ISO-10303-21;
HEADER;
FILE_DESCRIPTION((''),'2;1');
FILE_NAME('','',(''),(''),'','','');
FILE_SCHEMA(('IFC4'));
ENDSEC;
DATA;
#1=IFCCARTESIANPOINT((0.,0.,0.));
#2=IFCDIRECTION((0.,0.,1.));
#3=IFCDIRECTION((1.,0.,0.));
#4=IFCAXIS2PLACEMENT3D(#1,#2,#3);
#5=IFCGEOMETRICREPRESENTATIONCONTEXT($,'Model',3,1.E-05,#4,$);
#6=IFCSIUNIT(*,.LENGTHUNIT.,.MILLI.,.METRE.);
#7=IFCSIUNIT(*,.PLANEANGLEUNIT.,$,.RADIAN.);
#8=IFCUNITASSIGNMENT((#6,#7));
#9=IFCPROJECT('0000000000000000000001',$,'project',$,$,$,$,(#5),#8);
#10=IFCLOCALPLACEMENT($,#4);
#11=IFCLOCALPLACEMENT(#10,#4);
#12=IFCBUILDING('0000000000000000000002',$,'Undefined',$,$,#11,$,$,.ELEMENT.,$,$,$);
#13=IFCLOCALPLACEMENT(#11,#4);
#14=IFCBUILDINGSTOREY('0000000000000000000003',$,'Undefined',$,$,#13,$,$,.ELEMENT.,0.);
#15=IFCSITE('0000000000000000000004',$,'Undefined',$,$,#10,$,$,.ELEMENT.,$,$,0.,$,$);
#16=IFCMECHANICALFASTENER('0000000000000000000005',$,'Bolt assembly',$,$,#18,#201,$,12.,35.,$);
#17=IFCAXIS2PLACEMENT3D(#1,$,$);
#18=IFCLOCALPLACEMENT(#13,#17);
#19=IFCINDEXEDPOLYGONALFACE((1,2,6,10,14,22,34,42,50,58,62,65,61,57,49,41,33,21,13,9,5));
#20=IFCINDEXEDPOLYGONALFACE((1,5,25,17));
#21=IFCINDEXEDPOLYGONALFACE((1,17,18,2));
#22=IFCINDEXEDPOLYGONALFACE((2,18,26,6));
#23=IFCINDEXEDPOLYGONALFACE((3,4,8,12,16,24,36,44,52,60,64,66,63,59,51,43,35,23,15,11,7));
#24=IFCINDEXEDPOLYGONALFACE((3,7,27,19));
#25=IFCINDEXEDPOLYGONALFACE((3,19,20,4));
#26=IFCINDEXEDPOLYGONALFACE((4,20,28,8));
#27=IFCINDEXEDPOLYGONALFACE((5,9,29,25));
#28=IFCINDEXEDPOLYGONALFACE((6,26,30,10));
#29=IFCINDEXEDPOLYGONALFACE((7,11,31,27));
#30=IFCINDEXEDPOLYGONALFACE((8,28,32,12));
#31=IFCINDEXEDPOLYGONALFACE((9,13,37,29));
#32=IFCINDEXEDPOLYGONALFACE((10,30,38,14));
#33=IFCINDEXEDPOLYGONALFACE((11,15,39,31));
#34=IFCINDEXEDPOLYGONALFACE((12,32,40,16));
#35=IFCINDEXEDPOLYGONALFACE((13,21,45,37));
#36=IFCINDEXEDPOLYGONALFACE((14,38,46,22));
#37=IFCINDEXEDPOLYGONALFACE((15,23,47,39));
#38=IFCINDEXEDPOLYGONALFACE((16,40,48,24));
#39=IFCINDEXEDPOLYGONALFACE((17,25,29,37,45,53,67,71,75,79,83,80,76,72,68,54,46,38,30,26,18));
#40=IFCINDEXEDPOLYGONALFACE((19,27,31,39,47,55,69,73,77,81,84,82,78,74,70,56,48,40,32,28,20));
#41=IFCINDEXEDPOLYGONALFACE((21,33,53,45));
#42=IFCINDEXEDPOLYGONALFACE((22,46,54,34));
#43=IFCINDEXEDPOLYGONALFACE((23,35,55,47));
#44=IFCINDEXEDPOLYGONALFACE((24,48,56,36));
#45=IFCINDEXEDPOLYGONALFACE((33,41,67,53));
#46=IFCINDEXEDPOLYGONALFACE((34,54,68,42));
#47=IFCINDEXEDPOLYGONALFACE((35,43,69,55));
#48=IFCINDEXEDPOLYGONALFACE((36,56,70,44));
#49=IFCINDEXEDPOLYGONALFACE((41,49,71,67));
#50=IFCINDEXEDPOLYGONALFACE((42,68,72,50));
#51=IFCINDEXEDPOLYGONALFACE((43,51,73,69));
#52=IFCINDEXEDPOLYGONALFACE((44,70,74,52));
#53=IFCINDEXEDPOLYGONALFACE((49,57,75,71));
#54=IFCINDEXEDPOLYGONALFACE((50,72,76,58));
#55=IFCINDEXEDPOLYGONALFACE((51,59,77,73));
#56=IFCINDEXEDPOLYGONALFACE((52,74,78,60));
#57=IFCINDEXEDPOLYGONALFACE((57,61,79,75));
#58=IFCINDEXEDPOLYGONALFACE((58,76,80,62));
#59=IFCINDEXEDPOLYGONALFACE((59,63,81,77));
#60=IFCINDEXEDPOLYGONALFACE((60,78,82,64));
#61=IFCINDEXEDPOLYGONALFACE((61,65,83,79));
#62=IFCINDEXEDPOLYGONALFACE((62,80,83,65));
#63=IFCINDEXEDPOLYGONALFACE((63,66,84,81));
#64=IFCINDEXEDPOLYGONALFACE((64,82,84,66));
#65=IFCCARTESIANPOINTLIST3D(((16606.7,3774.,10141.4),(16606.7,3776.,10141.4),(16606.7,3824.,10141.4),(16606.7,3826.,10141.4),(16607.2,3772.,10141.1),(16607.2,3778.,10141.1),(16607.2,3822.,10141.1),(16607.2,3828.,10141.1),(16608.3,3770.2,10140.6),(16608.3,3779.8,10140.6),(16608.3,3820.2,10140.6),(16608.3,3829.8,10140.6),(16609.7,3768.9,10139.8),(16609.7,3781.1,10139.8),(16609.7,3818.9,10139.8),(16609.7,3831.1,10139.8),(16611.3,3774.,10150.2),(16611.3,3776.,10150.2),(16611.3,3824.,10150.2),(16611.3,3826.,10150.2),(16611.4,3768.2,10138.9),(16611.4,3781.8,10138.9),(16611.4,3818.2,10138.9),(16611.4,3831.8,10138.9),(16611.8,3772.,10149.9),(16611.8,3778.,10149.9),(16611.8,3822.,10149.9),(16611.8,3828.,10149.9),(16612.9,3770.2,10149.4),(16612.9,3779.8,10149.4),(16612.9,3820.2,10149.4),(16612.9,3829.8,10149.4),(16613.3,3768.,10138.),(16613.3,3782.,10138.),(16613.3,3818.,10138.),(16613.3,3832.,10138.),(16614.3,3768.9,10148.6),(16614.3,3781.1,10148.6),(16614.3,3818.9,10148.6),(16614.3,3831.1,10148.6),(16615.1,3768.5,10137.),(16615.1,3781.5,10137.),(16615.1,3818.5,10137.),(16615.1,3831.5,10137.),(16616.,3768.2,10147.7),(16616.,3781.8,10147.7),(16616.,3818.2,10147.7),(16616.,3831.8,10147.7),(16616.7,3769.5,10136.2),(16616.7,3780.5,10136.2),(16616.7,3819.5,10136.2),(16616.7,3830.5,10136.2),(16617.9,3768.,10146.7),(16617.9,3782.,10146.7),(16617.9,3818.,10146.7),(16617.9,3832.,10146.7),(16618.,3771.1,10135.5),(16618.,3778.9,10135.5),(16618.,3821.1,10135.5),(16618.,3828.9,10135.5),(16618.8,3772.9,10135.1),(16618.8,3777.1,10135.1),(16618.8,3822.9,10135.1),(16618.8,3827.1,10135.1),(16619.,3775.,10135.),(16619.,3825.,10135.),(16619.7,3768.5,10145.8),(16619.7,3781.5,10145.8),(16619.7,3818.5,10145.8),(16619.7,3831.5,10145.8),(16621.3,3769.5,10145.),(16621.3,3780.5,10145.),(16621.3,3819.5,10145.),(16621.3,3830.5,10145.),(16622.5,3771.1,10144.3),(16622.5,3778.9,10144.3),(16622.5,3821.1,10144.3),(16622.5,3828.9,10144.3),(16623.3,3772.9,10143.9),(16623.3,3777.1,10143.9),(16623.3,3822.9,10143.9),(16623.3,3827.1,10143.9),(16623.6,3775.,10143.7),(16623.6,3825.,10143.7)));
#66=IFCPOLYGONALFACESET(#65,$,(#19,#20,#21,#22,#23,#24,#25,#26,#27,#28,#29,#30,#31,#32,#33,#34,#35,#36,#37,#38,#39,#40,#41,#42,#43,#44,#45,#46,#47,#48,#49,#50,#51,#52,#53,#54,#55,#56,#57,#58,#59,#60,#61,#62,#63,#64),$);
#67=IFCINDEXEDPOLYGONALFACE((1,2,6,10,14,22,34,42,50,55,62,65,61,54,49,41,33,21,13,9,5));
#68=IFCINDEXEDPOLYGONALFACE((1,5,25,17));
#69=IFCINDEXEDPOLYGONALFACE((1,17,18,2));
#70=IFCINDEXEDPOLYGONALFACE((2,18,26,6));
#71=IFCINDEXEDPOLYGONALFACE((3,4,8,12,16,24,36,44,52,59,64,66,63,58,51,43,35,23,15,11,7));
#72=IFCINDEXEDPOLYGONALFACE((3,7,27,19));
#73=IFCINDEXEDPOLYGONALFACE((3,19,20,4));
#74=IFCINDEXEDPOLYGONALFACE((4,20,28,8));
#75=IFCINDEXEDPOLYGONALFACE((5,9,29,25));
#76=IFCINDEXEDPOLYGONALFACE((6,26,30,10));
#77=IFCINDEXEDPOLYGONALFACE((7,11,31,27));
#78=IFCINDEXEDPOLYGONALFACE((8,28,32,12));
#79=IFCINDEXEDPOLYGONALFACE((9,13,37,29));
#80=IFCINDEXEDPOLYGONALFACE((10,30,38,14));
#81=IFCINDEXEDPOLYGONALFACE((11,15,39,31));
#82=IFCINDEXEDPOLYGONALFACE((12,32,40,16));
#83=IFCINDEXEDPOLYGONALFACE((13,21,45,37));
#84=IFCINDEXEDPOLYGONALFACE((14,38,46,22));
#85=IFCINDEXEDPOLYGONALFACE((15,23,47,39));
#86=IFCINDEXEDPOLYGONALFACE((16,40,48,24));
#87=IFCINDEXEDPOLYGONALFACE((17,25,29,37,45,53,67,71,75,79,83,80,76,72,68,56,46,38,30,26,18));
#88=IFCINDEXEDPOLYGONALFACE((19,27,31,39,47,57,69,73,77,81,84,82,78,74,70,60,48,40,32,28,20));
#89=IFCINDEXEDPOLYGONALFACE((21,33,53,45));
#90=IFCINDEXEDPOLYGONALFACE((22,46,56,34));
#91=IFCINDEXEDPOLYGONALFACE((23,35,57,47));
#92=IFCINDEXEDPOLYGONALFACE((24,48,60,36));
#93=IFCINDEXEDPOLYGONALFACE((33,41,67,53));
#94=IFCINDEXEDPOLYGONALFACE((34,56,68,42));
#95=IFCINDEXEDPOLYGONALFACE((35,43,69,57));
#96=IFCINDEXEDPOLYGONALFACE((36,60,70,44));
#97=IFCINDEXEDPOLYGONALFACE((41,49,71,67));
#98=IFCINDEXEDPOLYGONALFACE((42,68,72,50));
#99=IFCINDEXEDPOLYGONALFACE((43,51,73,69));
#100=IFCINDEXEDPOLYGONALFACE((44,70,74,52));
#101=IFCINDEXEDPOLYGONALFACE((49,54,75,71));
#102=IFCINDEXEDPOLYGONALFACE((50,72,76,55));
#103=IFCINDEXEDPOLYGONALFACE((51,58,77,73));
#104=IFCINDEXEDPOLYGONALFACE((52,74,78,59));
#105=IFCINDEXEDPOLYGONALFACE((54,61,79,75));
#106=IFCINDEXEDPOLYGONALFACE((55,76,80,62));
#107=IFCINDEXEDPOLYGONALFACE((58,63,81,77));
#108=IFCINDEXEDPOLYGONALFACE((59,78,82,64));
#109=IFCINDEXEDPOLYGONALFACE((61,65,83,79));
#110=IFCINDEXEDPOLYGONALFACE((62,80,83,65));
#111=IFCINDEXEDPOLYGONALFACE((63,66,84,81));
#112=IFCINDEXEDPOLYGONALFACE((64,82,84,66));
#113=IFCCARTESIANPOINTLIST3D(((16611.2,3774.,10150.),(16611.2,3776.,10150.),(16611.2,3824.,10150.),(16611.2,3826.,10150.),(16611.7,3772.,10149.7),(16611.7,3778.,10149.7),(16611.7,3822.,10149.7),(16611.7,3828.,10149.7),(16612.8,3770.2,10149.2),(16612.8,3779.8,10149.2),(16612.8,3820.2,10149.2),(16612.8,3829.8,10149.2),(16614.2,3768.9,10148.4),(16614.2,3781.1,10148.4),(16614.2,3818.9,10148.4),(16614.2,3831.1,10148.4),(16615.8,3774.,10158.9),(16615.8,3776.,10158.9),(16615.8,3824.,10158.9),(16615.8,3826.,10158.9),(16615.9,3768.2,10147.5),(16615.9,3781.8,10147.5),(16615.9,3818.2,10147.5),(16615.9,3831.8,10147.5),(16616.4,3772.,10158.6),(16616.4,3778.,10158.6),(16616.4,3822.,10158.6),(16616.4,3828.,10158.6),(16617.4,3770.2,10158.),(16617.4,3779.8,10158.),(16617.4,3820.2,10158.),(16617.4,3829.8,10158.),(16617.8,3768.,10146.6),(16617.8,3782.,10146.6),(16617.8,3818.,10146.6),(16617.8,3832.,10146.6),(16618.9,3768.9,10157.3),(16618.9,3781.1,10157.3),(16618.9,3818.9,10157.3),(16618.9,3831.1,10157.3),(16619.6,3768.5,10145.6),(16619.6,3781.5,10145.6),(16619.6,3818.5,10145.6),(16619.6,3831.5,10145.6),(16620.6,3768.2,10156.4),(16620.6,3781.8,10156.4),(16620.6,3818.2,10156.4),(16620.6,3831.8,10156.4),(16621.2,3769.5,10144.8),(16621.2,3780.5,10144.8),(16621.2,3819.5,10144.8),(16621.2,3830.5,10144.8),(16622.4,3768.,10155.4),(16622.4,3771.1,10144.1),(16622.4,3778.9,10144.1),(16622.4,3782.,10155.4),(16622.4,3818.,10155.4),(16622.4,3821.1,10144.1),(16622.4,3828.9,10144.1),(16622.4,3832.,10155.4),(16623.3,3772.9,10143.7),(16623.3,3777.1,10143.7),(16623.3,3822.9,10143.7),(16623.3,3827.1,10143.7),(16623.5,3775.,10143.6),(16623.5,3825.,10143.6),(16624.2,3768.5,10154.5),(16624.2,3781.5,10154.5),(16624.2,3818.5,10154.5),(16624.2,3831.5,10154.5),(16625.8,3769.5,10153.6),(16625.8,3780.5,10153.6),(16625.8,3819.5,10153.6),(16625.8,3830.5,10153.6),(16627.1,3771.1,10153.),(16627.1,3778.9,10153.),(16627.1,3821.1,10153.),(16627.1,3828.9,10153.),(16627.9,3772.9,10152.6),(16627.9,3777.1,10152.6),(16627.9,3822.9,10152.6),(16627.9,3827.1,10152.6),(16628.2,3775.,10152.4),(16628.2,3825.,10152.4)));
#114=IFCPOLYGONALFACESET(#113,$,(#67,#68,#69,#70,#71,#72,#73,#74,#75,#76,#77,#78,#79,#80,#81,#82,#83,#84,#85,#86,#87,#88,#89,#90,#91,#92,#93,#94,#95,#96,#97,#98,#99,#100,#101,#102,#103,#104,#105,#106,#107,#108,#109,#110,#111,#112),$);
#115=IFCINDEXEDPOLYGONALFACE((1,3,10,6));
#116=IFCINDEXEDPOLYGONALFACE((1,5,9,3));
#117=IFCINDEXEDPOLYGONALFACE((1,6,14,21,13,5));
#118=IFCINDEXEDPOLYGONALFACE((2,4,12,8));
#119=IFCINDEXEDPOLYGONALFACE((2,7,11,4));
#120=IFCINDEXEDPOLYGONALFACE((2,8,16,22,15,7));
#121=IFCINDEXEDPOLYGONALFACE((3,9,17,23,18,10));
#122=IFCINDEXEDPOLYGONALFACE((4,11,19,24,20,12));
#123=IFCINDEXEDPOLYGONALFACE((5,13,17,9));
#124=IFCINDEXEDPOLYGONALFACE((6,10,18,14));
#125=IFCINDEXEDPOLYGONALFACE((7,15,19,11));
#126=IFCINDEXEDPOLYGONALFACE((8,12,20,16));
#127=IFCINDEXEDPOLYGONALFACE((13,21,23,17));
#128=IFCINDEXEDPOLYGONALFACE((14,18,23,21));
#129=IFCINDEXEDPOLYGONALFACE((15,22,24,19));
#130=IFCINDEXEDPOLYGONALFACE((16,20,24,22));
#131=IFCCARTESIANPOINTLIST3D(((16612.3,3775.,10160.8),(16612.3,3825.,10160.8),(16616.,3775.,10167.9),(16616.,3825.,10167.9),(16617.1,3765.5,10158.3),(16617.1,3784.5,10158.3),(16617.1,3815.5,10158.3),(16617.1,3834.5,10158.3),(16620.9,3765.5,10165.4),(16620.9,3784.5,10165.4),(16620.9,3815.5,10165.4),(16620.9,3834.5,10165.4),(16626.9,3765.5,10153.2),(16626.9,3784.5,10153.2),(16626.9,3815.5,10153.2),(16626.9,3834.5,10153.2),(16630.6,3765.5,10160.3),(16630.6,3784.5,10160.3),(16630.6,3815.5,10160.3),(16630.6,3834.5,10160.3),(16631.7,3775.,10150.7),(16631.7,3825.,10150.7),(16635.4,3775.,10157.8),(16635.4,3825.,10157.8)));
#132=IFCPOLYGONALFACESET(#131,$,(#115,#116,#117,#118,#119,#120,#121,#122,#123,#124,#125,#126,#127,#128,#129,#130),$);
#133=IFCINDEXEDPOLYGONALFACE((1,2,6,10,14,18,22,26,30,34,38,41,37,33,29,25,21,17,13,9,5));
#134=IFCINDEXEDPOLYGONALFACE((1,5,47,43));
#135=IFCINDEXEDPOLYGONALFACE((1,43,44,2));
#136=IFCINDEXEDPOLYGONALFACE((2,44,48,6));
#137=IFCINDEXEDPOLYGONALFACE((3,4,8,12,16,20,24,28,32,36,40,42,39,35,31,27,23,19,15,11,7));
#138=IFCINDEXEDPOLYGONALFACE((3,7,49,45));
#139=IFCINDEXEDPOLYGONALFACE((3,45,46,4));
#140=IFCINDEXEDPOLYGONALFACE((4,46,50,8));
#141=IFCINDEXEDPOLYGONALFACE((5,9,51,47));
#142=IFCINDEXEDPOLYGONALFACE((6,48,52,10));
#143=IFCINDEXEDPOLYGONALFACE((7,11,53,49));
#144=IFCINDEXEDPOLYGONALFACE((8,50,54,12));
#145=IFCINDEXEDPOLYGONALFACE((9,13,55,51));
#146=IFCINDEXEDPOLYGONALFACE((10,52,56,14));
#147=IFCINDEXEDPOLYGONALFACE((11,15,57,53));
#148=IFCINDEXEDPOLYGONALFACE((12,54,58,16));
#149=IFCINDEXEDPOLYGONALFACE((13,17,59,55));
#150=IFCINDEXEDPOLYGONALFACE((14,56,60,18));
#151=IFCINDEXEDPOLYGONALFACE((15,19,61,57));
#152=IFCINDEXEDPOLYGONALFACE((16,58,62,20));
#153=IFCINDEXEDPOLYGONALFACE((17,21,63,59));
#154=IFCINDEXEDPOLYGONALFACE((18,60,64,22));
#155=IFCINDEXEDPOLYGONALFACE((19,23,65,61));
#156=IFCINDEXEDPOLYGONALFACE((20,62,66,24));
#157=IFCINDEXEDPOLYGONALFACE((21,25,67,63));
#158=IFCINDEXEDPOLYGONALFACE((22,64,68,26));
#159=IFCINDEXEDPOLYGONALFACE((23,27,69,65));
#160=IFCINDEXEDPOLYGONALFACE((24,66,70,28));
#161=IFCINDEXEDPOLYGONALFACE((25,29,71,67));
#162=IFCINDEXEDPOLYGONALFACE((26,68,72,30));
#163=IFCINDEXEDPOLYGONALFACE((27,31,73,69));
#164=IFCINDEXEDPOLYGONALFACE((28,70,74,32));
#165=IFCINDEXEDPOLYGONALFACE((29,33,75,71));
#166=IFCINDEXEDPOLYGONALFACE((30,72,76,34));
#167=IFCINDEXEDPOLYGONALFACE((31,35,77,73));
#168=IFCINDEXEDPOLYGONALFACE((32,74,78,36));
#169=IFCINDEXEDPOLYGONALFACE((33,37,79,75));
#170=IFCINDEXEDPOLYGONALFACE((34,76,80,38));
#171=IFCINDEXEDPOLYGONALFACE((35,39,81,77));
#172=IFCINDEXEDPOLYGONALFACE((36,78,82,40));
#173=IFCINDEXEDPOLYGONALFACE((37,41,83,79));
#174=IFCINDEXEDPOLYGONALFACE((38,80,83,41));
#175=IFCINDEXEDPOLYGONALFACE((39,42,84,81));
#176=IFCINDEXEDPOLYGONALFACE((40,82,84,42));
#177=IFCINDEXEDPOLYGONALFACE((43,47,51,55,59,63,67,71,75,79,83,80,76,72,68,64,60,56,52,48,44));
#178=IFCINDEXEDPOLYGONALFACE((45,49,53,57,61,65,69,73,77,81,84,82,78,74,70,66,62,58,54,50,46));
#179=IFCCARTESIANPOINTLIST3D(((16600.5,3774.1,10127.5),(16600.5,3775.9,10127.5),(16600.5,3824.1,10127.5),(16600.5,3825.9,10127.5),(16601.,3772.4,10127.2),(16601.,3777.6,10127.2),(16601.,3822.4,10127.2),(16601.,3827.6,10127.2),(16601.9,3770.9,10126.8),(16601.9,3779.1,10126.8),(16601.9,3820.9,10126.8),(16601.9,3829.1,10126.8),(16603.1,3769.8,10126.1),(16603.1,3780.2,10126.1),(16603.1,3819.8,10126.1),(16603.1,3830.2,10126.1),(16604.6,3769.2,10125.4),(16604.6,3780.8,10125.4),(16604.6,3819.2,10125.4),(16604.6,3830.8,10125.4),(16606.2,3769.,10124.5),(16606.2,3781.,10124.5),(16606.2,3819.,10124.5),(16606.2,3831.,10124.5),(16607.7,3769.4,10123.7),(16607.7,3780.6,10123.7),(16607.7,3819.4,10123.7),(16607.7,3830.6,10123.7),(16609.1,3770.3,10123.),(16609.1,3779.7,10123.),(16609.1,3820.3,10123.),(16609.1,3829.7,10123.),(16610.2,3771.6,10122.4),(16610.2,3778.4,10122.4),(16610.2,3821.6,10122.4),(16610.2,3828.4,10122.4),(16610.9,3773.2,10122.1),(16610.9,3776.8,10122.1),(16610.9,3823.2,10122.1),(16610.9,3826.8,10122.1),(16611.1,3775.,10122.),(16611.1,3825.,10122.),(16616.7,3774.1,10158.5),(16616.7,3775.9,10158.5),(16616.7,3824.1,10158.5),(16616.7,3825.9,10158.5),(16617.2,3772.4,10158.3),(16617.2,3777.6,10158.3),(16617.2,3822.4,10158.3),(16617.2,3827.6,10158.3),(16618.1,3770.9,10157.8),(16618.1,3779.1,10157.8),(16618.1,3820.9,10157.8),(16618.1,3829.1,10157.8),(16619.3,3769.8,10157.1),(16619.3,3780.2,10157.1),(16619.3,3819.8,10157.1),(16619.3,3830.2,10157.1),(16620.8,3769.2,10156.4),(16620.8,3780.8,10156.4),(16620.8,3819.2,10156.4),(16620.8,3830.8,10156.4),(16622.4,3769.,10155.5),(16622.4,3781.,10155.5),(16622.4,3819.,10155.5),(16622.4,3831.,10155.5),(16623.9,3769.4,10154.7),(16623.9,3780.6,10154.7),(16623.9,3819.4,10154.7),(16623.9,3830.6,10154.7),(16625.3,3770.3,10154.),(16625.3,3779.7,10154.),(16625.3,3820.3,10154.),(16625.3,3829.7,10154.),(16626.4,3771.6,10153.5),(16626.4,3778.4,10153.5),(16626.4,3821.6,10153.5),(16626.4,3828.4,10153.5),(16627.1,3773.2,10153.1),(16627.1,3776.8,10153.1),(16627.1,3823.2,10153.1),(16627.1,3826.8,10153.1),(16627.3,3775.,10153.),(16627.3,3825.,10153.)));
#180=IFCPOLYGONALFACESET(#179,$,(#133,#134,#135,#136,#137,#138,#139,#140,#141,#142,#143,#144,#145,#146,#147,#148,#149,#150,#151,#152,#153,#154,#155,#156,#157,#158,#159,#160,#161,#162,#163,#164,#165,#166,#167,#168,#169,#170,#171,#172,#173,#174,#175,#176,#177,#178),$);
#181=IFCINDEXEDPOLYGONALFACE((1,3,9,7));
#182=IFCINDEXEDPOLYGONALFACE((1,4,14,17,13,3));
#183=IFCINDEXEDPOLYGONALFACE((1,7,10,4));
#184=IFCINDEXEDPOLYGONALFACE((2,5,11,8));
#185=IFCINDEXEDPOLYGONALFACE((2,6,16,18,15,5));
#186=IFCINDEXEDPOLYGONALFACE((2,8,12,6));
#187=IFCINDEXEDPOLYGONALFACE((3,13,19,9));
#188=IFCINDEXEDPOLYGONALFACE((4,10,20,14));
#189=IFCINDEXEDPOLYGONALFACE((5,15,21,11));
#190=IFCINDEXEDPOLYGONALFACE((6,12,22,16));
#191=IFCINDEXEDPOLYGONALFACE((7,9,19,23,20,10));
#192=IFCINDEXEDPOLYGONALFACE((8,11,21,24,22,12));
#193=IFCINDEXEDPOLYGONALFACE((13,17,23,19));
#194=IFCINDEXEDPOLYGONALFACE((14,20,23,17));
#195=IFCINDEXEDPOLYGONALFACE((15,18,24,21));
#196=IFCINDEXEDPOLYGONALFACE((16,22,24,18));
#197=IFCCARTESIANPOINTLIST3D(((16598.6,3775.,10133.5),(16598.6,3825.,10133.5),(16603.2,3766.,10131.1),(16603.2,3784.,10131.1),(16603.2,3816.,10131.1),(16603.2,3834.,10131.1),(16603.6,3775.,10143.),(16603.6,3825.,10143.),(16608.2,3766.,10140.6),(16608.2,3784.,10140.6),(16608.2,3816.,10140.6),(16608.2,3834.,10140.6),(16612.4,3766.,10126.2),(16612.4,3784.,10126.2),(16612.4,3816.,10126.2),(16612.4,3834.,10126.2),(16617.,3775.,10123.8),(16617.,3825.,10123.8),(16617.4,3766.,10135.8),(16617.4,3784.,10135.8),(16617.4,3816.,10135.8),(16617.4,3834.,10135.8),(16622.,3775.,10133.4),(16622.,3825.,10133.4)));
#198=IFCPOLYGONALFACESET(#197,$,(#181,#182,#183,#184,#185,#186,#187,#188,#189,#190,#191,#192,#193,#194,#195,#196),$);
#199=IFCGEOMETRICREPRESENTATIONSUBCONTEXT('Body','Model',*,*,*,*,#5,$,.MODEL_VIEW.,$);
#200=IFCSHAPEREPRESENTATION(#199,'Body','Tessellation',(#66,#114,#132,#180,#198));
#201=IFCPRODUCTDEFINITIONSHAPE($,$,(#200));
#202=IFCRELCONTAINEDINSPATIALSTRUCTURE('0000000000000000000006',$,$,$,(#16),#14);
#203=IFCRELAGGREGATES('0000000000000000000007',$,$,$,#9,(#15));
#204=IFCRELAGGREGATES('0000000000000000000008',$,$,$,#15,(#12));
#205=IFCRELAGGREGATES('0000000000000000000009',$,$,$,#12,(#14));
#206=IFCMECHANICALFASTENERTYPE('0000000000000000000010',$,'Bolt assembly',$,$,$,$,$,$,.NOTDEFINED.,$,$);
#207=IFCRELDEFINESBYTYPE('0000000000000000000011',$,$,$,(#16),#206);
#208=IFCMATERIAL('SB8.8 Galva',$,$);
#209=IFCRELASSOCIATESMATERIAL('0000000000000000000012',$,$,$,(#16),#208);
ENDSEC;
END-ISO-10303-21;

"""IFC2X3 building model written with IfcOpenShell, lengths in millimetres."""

from ifc_helpers import new_model, si_unit, frame, origin_with_axes, origin_2d_with_axis, place, context, subcontext, project, spatial, polyline, circle, outline, extrude, source, transform, mapped, material, type_object, element, save


model = new_model("IFC2X3")

# Units and contexts
model_context = context("Model", 3, precision=1e-05, world=origin_with_axes())
body_context = subcontext(model_context, "Body", "Model", "MODEL_VIEW")
ifc_project = project(units=[si_unit("LENGTHUNIT", "METRE", prefix="MILLI"), si_unit("PLANEANGLEUNIT", "RADIAN")], contexts=[model_context])

# Site, building, storey
site_placement = place(None, origin_with_axes())
site = spatial("IfcSite", under=ifc_project, at=site_placement, Name="Undefined", CompositionType="ELEMENT", RefElevation=0.0)
building_placement = place(site_placement, origin_with_axes())
building = spatial("IfcBuilding", under=site, at=building_placement, Name="Undefined", CompositionType="ELEMENT")
storey_placement = place(building_placement, origin_with_axes())
storey = spatial("IfcBuildingStorey", under=building, at=storey_placement, Name="Undefined", CompositionType="ELEMENT", Elevation=0.0)

# Mechanical fastener
mechanical_fastener_type = type_object("IfcMechanicalFastenerType", Name="Bolt assembly")
ifc_material_1 = material(Name="SB8.8 Galva")
shared_shape_1 = source(origin_with_axes(), body_context, "Body", "SweptSolid", [
    extrude(circle(Radius=7.0, at=origin_2d_with_axis()), frame((0.0, -0.1, 0.0), z_axis=(0.0, 1.0, 0.0), x_axis=(1.0, 0.0, 0.0)), (0.0, 0.0, 1.0), 9.9),
    extrude(circle(Radius=7.0, at=origin_2d_with_axis()), frame((0.0, -9.9, 0.0), z_axis=(0.0, 1.0, 0.0), x_axis=(1.0, 0.0, 0.0)), (0.0, 0.0, 1.0), 10.0),
    extrude(outline(polyline([(11.0, 0.0), (5.5, 9.5), (-5.5, 9.5), (-11.0, 0.0), (-5.5, -9.5), (5.5, -9.5), (11.0, 0.0)])), frame((0.0, -18.0, 0.0), z_axis=(0.0, 1.0, 0.0), x_axis=(1.0, 0.0, 0.0)), (0.0, 0.0, 1.0), 8.0),
    extrude(circle(Radius=6.0, at=origin_2d_with_axis()), frame((0.0, -10.0, 0.0), z_axis=(0.0, 1.0, 0.0), x_axis=(1.0, 0.0, 0.0)), (0.0, 0.0, 1.0), 35.0),
    extrude(outline(polyline([(10.4, 0.0), (5.2, 9.0), (-5.2, 9.0), (-10.4, 0.0), (-5.2, -9.0), (5.2, -9.0), (10.4, 0.0)])), frame((0.0, 9.8, 0.0), z_axis=(0.0, 1.0, 0.0), x_axis=(1.0, 0.0, 0.0)), (0.0, 0.0, 1.0), 10.8),
])
for number, where, z_axis, x_axis, name in (
    (1, (16617.4, 3800.0, 10146.9), (0.0, 1.0, 0.0), (0.886082, 0.0, -0.463529), "Bolt assembly"),
):
    element("IfcMechanicalFastener", number, at=place(storey_placement, frame(where, z_axis=z_axis, x_axis=x_axis)), inside=storey, type_object=mechanical_fastener_type, material=ifc_material_1, Name=name, NominalDiameter=12.0, NominalLength=35.0, context=body_context, shape_type="MappedRepresentation", body=[
        mapped(shared_shape_1, transform((0.0, 0.0, -25.0))),
        mapped(shared_shape_1, transform((0.0, 0.0, 25.0))),
    ])

save(model, "model.ifc")
